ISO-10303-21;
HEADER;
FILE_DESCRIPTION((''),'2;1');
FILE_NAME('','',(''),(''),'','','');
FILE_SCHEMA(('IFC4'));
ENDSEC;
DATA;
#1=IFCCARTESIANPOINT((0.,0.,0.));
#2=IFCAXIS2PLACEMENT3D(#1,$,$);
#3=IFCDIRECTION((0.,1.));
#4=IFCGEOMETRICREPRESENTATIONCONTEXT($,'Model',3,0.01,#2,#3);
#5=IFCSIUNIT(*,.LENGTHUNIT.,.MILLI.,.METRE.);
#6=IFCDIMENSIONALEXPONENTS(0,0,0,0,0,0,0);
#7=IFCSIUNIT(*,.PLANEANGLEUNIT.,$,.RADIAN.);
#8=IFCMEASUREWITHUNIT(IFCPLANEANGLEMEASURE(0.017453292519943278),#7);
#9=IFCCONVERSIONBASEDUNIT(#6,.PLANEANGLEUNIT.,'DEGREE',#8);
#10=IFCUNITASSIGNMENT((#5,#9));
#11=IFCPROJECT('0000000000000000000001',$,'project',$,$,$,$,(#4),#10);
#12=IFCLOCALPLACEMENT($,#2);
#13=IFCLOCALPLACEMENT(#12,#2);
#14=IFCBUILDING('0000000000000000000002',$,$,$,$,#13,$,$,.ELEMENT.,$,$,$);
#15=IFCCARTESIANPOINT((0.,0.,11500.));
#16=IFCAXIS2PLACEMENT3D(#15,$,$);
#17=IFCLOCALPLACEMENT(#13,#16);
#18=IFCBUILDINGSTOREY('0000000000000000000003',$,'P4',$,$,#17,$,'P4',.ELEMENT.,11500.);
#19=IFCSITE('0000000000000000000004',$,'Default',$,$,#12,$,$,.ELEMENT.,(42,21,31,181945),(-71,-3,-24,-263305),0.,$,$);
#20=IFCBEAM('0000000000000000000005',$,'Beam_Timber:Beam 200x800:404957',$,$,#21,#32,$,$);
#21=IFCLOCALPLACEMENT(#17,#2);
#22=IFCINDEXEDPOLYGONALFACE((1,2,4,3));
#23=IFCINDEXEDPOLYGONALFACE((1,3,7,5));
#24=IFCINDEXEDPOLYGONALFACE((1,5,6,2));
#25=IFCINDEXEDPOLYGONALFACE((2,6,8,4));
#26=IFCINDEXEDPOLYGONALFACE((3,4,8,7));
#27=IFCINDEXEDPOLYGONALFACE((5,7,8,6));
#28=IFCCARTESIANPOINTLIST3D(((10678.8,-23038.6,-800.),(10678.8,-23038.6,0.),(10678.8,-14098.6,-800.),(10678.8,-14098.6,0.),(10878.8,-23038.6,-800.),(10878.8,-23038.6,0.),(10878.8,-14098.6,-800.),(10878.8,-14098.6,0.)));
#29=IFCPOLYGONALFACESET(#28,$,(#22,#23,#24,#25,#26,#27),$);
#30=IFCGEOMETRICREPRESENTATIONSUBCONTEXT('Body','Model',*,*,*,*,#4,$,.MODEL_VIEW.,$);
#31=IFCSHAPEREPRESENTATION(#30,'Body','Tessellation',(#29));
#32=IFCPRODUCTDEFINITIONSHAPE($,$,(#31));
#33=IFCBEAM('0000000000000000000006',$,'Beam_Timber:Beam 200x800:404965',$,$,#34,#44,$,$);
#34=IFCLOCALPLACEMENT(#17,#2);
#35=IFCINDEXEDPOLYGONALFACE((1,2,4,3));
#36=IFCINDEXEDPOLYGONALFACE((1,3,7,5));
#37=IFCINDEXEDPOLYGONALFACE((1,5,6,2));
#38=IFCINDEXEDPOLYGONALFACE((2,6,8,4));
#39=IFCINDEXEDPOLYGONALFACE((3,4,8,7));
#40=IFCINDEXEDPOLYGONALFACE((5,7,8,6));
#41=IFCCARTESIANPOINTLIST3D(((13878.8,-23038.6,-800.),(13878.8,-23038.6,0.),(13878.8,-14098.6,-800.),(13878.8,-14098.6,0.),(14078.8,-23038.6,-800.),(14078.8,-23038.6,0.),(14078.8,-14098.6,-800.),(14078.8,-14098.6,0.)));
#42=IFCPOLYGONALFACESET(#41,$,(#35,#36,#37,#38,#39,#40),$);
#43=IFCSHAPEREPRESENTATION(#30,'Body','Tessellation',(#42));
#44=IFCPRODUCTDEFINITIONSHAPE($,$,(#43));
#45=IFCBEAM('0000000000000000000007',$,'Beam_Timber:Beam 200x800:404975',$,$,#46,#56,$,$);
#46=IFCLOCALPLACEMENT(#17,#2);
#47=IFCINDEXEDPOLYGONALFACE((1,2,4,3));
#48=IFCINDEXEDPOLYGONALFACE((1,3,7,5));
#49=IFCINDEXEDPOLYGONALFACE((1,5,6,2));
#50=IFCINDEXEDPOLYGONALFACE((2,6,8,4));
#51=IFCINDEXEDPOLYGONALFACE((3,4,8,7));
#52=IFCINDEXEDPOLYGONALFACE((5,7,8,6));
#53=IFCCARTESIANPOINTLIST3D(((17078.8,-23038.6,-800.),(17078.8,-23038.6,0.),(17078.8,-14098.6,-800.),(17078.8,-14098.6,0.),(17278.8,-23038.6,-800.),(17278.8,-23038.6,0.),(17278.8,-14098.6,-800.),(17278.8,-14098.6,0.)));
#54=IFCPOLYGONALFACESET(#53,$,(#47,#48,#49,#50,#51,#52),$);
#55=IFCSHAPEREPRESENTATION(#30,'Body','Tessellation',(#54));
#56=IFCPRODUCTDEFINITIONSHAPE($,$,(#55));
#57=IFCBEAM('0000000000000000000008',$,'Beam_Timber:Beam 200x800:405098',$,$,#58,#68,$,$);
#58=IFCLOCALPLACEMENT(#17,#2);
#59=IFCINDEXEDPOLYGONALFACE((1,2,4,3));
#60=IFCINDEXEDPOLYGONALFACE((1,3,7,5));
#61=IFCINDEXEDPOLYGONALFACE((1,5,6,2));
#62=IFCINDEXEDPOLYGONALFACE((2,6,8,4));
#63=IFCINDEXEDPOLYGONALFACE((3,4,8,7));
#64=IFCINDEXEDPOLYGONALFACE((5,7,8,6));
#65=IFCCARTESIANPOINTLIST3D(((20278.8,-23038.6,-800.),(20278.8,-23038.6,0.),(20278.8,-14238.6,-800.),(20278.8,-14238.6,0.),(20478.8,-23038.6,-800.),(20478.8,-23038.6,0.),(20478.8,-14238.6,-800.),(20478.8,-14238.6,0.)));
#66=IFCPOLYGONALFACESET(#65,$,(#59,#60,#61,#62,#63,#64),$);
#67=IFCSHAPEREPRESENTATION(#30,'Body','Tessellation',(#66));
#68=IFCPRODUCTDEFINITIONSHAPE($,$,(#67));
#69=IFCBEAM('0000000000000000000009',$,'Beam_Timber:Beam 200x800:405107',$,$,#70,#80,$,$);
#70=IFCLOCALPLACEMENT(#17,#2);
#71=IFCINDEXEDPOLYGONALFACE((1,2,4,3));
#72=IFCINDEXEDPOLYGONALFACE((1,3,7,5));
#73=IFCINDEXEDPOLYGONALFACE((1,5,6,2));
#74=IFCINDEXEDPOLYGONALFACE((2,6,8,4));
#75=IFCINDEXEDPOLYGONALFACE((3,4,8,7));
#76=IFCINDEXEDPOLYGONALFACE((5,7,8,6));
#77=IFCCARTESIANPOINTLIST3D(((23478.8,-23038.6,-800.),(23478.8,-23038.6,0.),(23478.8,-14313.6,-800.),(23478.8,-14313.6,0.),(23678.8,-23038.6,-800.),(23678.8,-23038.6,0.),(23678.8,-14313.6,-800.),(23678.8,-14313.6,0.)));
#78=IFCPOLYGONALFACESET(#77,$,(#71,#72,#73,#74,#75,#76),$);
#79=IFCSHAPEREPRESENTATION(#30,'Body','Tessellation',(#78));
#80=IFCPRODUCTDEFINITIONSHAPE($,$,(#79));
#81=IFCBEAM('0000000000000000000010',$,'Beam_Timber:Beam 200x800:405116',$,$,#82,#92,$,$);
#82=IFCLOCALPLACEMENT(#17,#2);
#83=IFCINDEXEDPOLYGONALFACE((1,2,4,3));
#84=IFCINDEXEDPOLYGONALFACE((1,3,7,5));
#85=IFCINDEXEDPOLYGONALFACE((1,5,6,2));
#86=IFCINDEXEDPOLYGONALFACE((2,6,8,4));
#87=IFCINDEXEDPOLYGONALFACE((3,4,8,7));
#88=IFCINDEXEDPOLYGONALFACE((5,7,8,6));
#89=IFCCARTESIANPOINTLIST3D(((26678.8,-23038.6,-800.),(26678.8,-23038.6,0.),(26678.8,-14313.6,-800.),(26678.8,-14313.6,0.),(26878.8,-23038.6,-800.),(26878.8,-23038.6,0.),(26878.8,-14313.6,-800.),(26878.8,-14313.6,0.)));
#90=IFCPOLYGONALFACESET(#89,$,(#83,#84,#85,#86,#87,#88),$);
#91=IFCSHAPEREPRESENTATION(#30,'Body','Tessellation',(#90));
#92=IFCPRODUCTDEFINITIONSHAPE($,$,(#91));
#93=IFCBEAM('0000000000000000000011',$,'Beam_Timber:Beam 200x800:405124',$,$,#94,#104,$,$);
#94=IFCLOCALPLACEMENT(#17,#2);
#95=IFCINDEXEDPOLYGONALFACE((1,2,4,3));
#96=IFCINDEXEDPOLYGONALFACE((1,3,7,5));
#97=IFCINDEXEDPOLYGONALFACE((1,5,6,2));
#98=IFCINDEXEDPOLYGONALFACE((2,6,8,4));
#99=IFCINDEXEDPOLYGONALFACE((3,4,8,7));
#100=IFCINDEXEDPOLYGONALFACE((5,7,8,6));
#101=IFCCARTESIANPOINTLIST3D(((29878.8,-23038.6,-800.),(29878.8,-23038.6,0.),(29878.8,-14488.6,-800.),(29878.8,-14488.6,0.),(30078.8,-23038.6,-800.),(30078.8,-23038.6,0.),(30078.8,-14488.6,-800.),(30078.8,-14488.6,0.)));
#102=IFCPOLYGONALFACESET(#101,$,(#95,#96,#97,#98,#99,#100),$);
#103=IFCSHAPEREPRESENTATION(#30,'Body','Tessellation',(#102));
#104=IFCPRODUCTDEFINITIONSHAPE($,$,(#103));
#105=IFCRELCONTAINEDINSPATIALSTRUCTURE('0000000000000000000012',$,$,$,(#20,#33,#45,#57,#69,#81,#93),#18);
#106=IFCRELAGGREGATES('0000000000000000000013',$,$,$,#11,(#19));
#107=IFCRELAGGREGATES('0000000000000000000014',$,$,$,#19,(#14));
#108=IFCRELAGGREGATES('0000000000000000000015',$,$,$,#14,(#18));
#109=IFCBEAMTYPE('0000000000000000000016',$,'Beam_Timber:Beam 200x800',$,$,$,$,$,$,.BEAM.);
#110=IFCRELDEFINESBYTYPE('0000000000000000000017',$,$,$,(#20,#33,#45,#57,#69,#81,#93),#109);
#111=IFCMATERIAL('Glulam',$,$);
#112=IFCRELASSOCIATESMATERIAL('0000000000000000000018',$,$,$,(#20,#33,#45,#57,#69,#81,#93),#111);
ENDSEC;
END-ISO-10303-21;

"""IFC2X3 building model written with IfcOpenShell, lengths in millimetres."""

from ifc_helpers import new_model, entity, si_unit, converted_unit, direction, frame, frame_2d, origin, place, context, subcontext, project, spatial, rectangle, extrude, material, type_object, element, save


model = new_model("IFC2X3")

# Units and contexts
model_context = context("Model", 3, precision=0.01, world=origin(), true_north=direction((0.0, 1.0)))
body_context = subcontext(model_context, "Body", "Model", "MODEL_VIEW")
ifc_project = project(units=[si_unit("LENGTHUNIT", "METRE", prefix="MILLI"), converted_unit("PLANEANGLEUNIT", "DEGREE", entity("IfcPlaneAngleMeasure", 0.017453292519943278), si_unit("PLANEANGLEUNIT", "RADIAN"), dimensions=[0, 0, 0, 0, 0, 0, 0])], contexts=[model_context])

# Site, building, storey
site_placement = place(None, origin())
site = spatial("IfcSite", under=ifc_project, at=site_placement, Name="Default", CompositionType="ELEMENT", RefLatitude=(42, 21, 31, 181945), RefLongitude=(-71, -3, -24, -263305), RefElevation=0.0)
building_placement = place(site_placement, origin())
building = spatial("IfcBuilding", under=site, at=building_placement, CompositionType="ELEMENT")
storey_placement = place(building_placement, frame((0.0, 0.0, 11500.0)))
storey = spatial("IfcBuildingStorey", under=building, at=storey_placement, Name="P4", LongName="P4", CompositionType="ELEMENT", Elevation=11500.0)

# Shared definitions
ifc_material = material(Name="Glulam")

# Beams
beam_type_1 = type_object("IfcBeamType", Name="Beam_Timber:Beam 200x800", PredefinedType="BEAM")
for number, where, z_axis, x_axis, name in (
    (1, (10778.8, -22938.6, 0.0), (0.0, 0.0, 1.0), (0.0, 1.0, 0.0), "Beam_Timber:Beam 200x800:404957"),
    (2, (13978.8, -22938.6, 0.0), (0.0, 0.0, 1.0), (0.0, 1.0, 0.0), "Beam_Timber:Beam 200x800:404965"),
    (3, (17178.8, -22938.6, 0.0), (0.0, 0.0, 1.0), (0.0, 1.0, 0.0), "Beam_Timber:Beam 200x800:404975"),
):
    element("IfcBeam", number, at=place(storey_placement, frame(where, z_axis=z_axis, x_axis=x_axis)), inside=storey, type_object=beam_type_1, material=ifc_material, Name=name, context=body_context, shape_type="SweptSolid", body=[
        extrude(rectangle(XDim=800.0, YDim=200.0, at=frame_2d((0.0, 0.0), x_axis=(1.0, 0.0))), frame((-100.0, 0.0, -400.0), z_axis=(1.0, 0.0, 0.0), x_axis=(0.0, 0.0, -1.0)), (0.0, 0.0, 1.0), 8940.0),
    ])
beam_1_placement = place(storey_placement, frame((20378.8, -22938.6, 0.0), z_axis=(0.0, 0.0, 1.0), x_axis=(0.0, 1.0, 0.0)))
element("IfcBeam", 4, at=beam_1_placement, inside=storey, type_object=beam_type_1, material=ifc_material, Name="Beam_Timber:Beam 200x800:405098", context=body_context, shape_type="SweptSolid", body=[
    extrude(rectangle(XDim=800.0, YDim=200.0, at=frame_2d((0.0, 0.0), x_axis=(1.0, 0.0))), frame((-100.0, 0.0, -400.0), z_axis=(1.0, 0.0, 0.0), x_axis=(0.0, 0.0, -1.0)), (0.0, 0.0, 1.0), 8800.0),
])
for number, where, z_axis, x_axis, name in (
    (5, (23578.8, -22938.6, 0.0), (0.0, 0.0, 1.0), (0.0, 1.0, 0.0), "Beam_Timber:Beam 200x800:405107"),
    (6, (26778.8, -22938.6, 0.0), (0.0, 0.0, 1.0), (0.0, 1.0, 0.0), "Beam_Timber:Beam 200x800:405116"),
):
    element("IfcBeam", number, at=place(storey_placement, frame(where, z_axis=z_axis, x_axis=x_axis)), inside=storey, type_object=beam_type_1, material=ifc_material, Name=name, context=body_context, shape_type="SweptSolid", body=[
        extrude(rectangle(XDim=800.0, YDim=200.0, at=frame_2d((0.0, 0.0), x_axis=(1.0, 0.0))), frame((-100.0, 0.0, -400.0), z_axis=(1.0, 0.0, 0.0), x_axis=(0.0, 0.0, -1.0)), (0.0, 0.0, 1.0), 8725.0),
    ])
beam_2_placement = place(storey_placement, frame((29978.8, -22938.6, 0.0), z_axis=(0.0, 0.0, 1.0), x_axis=(0.0, 1.0, 0.0)))
element("IfcBeam", 7, at=beam_2_placement, inside=storey, type_object=beam_type_1, material=ifc_material, Name="Beam_Timber:Beam 200x800:405124", context=body_context, shape_type="SweptSolid", body=[
    extrude(rectangle(XDim=800.0, YDim=200.0, at=frame_2d((0.0, 0.0), x_axis=(1.0, 0.0))), frame((-100.0, 0.0, -400.0), z_axis=(1.0, 0.0, 0.0), x_axis=(0.0, 0.0, -1.0)), (0.0, 0.0, 1.0), 8550.0),
])

save(model, "model.ifc")
